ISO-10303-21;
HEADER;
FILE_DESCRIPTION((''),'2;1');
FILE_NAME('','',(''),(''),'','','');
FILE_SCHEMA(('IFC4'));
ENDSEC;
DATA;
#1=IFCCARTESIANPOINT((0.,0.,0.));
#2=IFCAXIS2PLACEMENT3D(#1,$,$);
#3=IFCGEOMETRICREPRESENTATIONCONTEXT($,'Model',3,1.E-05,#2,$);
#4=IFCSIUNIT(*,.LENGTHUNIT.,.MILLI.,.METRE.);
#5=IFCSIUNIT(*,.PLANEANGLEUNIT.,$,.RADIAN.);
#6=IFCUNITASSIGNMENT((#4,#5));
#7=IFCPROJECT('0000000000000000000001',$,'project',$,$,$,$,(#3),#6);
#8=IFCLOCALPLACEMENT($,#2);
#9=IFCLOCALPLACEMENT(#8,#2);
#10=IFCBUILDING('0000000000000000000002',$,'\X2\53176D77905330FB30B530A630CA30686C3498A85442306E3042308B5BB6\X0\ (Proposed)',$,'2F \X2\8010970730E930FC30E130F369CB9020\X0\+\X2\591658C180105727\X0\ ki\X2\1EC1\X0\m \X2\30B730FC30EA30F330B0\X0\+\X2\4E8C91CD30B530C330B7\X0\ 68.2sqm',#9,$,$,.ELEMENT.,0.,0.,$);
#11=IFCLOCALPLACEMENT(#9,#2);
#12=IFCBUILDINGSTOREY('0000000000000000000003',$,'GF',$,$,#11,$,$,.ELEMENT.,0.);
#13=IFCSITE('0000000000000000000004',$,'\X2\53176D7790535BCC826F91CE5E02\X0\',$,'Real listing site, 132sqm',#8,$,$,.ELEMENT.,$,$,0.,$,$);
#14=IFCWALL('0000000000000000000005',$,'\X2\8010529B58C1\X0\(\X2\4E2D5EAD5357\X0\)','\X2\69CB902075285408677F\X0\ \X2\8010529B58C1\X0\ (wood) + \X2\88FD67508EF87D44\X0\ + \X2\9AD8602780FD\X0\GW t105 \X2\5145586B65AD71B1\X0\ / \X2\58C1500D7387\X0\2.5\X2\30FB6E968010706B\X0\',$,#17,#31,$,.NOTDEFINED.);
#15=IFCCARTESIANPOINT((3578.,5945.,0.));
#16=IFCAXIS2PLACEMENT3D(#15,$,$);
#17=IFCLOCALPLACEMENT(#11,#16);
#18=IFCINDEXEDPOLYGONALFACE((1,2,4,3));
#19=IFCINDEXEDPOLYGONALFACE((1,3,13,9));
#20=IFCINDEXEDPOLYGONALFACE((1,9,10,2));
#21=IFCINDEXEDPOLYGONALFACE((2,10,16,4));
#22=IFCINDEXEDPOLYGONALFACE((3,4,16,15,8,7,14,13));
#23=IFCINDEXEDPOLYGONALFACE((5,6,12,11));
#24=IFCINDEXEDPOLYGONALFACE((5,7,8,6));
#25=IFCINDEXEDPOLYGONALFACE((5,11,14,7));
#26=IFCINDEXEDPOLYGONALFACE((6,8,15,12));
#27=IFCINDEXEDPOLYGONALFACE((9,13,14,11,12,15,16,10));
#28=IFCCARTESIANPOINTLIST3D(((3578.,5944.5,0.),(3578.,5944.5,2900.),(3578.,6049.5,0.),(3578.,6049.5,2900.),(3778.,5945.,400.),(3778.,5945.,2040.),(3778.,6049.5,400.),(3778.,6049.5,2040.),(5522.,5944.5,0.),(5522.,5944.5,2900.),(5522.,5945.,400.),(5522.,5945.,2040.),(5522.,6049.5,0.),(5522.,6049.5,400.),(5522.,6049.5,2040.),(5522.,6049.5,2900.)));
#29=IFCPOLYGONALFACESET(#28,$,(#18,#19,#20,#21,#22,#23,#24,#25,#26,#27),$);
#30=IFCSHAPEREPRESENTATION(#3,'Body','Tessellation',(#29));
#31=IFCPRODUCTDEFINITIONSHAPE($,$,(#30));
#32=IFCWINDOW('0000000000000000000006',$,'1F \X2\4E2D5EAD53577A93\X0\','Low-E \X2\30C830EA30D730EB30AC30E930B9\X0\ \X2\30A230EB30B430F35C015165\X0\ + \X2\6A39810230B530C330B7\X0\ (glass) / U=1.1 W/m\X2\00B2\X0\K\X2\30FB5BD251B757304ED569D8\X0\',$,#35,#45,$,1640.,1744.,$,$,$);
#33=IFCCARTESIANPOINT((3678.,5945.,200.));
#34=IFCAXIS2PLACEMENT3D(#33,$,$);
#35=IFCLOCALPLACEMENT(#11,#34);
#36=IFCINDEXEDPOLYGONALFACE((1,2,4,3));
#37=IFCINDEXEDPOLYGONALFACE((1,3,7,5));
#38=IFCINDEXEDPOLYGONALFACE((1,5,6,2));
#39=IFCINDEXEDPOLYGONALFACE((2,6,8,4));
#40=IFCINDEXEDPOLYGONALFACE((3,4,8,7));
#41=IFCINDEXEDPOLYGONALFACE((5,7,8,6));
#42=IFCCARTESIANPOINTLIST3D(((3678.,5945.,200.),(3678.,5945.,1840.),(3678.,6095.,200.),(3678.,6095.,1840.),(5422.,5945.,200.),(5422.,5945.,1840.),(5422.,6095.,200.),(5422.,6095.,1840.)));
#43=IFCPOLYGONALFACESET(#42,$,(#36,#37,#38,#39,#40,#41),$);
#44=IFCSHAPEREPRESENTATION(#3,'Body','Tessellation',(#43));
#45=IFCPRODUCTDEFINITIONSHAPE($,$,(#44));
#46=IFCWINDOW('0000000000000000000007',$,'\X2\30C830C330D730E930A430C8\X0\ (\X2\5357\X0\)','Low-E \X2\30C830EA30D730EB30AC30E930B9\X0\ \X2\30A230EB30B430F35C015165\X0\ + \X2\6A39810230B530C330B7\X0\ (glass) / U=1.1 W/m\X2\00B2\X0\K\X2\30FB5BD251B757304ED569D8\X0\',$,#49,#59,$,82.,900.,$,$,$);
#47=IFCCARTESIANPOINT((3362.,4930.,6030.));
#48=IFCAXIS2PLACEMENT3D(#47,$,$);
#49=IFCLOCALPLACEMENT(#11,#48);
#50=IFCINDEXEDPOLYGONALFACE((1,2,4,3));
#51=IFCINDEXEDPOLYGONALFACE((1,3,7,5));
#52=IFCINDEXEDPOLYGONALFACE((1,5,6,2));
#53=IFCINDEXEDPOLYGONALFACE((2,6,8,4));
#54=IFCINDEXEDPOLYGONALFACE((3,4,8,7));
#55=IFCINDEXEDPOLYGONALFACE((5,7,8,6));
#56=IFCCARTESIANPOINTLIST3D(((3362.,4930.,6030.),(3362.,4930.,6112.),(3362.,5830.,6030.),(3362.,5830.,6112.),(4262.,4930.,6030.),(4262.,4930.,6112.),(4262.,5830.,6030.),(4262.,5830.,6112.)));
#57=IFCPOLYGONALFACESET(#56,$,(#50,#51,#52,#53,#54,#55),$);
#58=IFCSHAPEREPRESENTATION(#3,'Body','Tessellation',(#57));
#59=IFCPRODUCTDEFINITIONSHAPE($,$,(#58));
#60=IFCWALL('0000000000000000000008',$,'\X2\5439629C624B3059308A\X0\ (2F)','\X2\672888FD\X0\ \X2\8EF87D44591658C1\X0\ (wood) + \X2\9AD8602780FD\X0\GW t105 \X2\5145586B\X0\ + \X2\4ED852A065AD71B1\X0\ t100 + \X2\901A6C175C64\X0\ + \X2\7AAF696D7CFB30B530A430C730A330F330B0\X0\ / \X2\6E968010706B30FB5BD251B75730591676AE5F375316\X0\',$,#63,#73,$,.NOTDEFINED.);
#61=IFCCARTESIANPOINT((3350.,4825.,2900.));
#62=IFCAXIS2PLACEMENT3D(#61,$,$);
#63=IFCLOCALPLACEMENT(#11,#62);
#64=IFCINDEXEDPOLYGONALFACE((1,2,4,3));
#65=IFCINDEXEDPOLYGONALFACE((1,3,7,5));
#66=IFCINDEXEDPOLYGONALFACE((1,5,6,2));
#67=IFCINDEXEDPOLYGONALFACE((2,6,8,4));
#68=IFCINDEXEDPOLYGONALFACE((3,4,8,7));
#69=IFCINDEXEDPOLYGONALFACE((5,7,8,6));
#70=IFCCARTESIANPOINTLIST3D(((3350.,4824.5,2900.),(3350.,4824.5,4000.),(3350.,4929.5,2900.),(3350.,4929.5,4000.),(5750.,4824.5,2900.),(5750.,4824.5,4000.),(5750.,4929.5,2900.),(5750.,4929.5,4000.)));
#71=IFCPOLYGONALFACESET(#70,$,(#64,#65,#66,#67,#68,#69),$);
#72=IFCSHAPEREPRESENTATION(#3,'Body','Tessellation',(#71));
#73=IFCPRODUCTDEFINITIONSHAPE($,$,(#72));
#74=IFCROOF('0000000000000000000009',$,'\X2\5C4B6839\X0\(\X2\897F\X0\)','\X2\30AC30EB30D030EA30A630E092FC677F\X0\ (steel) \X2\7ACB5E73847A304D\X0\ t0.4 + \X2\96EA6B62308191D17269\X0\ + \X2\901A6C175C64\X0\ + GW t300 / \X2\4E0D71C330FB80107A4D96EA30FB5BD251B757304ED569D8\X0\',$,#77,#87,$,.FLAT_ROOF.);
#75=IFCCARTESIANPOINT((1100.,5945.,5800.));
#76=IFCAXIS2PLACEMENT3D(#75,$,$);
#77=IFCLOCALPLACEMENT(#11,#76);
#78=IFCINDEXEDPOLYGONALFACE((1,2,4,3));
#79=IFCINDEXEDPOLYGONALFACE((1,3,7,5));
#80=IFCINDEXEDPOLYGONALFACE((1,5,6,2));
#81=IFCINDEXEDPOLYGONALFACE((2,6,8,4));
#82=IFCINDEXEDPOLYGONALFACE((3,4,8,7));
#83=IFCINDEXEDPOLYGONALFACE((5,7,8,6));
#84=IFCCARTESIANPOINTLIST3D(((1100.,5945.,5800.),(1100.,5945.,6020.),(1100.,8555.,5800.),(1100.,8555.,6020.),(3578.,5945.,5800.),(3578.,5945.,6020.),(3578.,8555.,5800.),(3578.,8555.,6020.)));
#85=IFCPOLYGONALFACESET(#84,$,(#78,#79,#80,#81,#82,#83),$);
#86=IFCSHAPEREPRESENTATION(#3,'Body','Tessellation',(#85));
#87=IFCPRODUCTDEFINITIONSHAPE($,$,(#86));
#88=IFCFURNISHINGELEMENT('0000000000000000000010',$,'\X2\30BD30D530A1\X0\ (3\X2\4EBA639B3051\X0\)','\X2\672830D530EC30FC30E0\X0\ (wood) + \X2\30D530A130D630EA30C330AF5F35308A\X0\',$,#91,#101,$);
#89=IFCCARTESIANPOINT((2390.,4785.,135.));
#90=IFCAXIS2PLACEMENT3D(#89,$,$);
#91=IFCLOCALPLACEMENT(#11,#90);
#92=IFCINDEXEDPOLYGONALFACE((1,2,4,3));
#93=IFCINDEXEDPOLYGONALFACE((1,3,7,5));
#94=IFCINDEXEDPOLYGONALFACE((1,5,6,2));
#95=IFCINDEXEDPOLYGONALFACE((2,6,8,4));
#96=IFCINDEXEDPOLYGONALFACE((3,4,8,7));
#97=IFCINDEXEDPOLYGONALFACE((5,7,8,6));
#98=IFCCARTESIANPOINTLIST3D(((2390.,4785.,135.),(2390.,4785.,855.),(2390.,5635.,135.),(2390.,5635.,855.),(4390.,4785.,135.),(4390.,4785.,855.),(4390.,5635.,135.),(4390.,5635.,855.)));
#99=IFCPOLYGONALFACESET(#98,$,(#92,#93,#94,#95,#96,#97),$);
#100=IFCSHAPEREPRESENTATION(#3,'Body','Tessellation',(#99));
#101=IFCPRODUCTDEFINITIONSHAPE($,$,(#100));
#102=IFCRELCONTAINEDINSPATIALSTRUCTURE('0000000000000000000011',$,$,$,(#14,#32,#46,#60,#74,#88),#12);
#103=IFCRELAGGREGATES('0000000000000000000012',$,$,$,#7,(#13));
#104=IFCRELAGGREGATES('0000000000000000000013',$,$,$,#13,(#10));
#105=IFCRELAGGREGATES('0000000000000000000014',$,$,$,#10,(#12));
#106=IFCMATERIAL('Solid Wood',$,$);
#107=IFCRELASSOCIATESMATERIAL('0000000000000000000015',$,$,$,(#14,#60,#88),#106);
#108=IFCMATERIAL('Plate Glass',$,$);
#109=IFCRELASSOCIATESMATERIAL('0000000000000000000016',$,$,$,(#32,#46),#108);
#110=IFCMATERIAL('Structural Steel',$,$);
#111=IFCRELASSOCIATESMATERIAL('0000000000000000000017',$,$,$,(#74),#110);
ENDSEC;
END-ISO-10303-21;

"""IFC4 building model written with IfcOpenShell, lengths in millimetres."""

from ifc_helpers import new_model, si_unit, frame, frame_2d, origin, place, context, project, spatial, rectangle, extrude, material, element, fill, save


model = new_model("IFC4")

# Units and contexts
model_context = context("Model", 3, precision=1e-05, world=origin())
ifc_project = project(units=[si_unit("LENGTHUNIT", "METRE", prefix="MILLI"), si_unit("PLANEANGLEUNIT", "RADIAN")], contexts=[model_context])

# Site, building, storey
site_placement = place(None, origin())
site = spatial("IfcSite", under=ifc_project, at=site_placement, Name="北海道富良野市", ObjectType="Real listing site, 132sqm", CompositionType="ELEMENT", RefElevation=0.0)
building_placement = place(site_placement, origin())
building = spatial("IfcBuilding", under=site, at=building_placement, Name="北海道・サウナと水風呂のある家 (Proposed)", ObjectType="2F 耐震ラーメン構造+外壁耐圧 kiềm シーリング+二重サッシ 68.2sqm", CompositionType="ELEMENT", ElevationOfRefHeight=0.0, ElevationOfTerrain=0.0)
storey_placement = place(building_placement, origin())
storey = spatial("IfcBuildingStorey", under=building, at=storey_placement, Name="GF", CompositionType="ELEMENT", Elevation=0.0)

# Shared definitions
ifc_material_1 = material(Name="Solid Wood")

# Wall, opening, window
wall_1_placement = place(storey_placement, frame((3578.0, 5945.0, 0.0)))
wall_1 = element("IfcWall", 1, at=wall_1_placement, inside=storey, material=ifc_material_1, Name="耐力壁(中庭南)", Description="構造用合板 耐力壁 (wood) + 製材軸組 + 高性能GW t105 充填断熱 / 壁倍率2.5・準耐火", PredefinedType="NOTDEFINED", context=model_context, shape_type="SweptSolid", body=[
    extrude(rectangle(XDim=1944.0, YDim=105.0, at=frame_2d((972.0, 52.0))), frame((3578.0, 5945.0, 0.0)), (0.0, 0.0, 1.0), 2900.0),
])
opening_placement = place(storey_placement, frame((3678.0, 5945.0, 200.0)))
opening = element("IfcOpeningElement", 2, at=opening_placement, cuts=wall_1, PredefinedType="NOTDEFINED", context=model_context, shape_type="SweptSolid", body=[
    extrude(rectangle(XDim=1744.0, YDim=150.0, at=frame_2d((872.0, 75.0))), frame((3678.0, 5945.0, 200.0)), (0.0, 0.0, 1.0), 1640.0),
])
ifc_material_2 = material(Name="Plate Glass")
window_1_placement = place(storey_placement, frame((3678.0, 5945.0, 200.0)))
window_1 = element("IfcWindow", 3, at=window_1_placement, inside=storey, material=ifc_material_2, Name="1F 中庭南窓", Description="Low-E トリプルガラス アルゴン封入 + 樹脂サッシ (glass) / U=1.1 W/m²K・寒冷地仕様", OverallHeight=1640.0, OverallWidth=1744.0, context=model_context, shape_type="SweptSolid", body=[
    extrude(rectangle(XDim=1744.0, YDim=150.0, at=frame_2d((872.0, 75.0))), frame((3678.0, 5945.0, 200.0)), (0.0, 0.0, 1.0), 1640.0),
])
fill(opening, window_1)

# Window
window_2_placement = place(storey_placement, frame((3362.0, 4930.0, 6030.0)))
element("IfcWindow", 4, at=window_2_placement, inside=storey, material=ifc_material_2, Name="トップライト (南)", Description="Low-E トリプルガラス アルゴン封入 + 樹脂サッシ (glass) / U=1.1 W/m²K・寒冷地仕様", OverallHeight=82.0, OverallWidth=900.0, context=model_context, shape_type="SweptSolid", body=[
    extrude(rectangle(XDim=900.0, YDim=900.0, at=frame_2d((450.0, 450.0))), frame((3362.0, 4930.0, 6030.0)), (0.0, 0.0, 1.0), 82.0),
])

# Wall
wall_2_placement = place(storey_placement, frame((3350.0, 4825.0, 2900.0)))
element("IfcWall", 5, at=wall_2_placement, inside=storey, material=ifc_material_1, Name="吹抜手すり (2F)", Description="木製 軸組外壁 (wood) + 高性能GW t105 充填 + 付加断熱 t100 + 通気層 + 窯業系サイディング / 準耐火・寒冷地外皮強化", PredefinedType="NOTDEFINED", context=model_context, shape_type="SweptSolid", body=[
    extrude(rectangle(XDim=2400.0, YDim=105.0, at=frame_2d((1200.0, 52.0))), frame((3350.0, 4825.0, 2900.0)), (0.0, 0.0, 1.0), 1100.0),
])

# Roof
ifc_material_3 = material(Name="Structural Steel")
for number, where, name in (
    (6, (1100.0, 5945.0, 5800.0), "屋根(西)"),
):
    element("IfcRoof", number, at=place(storey_placement, frame(where)), inside=storey, material=ifc_material_3, Name=name, Description="ガルバリウム鋼板 (steel) 立平葺き t0.4 + 雪止め金物 + 通気層 + GW t300 / 不燃・耐積雪・寒冷地仕様", PredefinedType="FLAT_ROOF", context=model_context, shape_type="SweptSolid", body=[
        extrude(rectangle(XDim=2478.0, YDim=2610.0, at=frame_2d((1239.0, 1305.0))), frame((1100.0, 5945.0, 5800.0)), (0.0, 0.0, 1.0), 220.0),
    ])

# Furnishing element
furnishing_placement = place(storey_placement, frame((2390.0, 4785.0, 135.0)))
element("IfcFurnishingElement", 7, at=furnishing_placement, inside=storey, material=ifc_material_1, Name="ソファ (3人掛け)", Description="木フレーム (wood) + ファブリック張り", context=model_context, shape_type="SweptSolid", body=[
    extrude(rectangle(XDim=2000.0, YDim=850.0, at=frame_2d((1000.0, 425.0))), frame((2390.0, 4785.0, 135.0)), (0.0, 0.0, 1.0), 720.0),
])

save(model, "model.ifc")
